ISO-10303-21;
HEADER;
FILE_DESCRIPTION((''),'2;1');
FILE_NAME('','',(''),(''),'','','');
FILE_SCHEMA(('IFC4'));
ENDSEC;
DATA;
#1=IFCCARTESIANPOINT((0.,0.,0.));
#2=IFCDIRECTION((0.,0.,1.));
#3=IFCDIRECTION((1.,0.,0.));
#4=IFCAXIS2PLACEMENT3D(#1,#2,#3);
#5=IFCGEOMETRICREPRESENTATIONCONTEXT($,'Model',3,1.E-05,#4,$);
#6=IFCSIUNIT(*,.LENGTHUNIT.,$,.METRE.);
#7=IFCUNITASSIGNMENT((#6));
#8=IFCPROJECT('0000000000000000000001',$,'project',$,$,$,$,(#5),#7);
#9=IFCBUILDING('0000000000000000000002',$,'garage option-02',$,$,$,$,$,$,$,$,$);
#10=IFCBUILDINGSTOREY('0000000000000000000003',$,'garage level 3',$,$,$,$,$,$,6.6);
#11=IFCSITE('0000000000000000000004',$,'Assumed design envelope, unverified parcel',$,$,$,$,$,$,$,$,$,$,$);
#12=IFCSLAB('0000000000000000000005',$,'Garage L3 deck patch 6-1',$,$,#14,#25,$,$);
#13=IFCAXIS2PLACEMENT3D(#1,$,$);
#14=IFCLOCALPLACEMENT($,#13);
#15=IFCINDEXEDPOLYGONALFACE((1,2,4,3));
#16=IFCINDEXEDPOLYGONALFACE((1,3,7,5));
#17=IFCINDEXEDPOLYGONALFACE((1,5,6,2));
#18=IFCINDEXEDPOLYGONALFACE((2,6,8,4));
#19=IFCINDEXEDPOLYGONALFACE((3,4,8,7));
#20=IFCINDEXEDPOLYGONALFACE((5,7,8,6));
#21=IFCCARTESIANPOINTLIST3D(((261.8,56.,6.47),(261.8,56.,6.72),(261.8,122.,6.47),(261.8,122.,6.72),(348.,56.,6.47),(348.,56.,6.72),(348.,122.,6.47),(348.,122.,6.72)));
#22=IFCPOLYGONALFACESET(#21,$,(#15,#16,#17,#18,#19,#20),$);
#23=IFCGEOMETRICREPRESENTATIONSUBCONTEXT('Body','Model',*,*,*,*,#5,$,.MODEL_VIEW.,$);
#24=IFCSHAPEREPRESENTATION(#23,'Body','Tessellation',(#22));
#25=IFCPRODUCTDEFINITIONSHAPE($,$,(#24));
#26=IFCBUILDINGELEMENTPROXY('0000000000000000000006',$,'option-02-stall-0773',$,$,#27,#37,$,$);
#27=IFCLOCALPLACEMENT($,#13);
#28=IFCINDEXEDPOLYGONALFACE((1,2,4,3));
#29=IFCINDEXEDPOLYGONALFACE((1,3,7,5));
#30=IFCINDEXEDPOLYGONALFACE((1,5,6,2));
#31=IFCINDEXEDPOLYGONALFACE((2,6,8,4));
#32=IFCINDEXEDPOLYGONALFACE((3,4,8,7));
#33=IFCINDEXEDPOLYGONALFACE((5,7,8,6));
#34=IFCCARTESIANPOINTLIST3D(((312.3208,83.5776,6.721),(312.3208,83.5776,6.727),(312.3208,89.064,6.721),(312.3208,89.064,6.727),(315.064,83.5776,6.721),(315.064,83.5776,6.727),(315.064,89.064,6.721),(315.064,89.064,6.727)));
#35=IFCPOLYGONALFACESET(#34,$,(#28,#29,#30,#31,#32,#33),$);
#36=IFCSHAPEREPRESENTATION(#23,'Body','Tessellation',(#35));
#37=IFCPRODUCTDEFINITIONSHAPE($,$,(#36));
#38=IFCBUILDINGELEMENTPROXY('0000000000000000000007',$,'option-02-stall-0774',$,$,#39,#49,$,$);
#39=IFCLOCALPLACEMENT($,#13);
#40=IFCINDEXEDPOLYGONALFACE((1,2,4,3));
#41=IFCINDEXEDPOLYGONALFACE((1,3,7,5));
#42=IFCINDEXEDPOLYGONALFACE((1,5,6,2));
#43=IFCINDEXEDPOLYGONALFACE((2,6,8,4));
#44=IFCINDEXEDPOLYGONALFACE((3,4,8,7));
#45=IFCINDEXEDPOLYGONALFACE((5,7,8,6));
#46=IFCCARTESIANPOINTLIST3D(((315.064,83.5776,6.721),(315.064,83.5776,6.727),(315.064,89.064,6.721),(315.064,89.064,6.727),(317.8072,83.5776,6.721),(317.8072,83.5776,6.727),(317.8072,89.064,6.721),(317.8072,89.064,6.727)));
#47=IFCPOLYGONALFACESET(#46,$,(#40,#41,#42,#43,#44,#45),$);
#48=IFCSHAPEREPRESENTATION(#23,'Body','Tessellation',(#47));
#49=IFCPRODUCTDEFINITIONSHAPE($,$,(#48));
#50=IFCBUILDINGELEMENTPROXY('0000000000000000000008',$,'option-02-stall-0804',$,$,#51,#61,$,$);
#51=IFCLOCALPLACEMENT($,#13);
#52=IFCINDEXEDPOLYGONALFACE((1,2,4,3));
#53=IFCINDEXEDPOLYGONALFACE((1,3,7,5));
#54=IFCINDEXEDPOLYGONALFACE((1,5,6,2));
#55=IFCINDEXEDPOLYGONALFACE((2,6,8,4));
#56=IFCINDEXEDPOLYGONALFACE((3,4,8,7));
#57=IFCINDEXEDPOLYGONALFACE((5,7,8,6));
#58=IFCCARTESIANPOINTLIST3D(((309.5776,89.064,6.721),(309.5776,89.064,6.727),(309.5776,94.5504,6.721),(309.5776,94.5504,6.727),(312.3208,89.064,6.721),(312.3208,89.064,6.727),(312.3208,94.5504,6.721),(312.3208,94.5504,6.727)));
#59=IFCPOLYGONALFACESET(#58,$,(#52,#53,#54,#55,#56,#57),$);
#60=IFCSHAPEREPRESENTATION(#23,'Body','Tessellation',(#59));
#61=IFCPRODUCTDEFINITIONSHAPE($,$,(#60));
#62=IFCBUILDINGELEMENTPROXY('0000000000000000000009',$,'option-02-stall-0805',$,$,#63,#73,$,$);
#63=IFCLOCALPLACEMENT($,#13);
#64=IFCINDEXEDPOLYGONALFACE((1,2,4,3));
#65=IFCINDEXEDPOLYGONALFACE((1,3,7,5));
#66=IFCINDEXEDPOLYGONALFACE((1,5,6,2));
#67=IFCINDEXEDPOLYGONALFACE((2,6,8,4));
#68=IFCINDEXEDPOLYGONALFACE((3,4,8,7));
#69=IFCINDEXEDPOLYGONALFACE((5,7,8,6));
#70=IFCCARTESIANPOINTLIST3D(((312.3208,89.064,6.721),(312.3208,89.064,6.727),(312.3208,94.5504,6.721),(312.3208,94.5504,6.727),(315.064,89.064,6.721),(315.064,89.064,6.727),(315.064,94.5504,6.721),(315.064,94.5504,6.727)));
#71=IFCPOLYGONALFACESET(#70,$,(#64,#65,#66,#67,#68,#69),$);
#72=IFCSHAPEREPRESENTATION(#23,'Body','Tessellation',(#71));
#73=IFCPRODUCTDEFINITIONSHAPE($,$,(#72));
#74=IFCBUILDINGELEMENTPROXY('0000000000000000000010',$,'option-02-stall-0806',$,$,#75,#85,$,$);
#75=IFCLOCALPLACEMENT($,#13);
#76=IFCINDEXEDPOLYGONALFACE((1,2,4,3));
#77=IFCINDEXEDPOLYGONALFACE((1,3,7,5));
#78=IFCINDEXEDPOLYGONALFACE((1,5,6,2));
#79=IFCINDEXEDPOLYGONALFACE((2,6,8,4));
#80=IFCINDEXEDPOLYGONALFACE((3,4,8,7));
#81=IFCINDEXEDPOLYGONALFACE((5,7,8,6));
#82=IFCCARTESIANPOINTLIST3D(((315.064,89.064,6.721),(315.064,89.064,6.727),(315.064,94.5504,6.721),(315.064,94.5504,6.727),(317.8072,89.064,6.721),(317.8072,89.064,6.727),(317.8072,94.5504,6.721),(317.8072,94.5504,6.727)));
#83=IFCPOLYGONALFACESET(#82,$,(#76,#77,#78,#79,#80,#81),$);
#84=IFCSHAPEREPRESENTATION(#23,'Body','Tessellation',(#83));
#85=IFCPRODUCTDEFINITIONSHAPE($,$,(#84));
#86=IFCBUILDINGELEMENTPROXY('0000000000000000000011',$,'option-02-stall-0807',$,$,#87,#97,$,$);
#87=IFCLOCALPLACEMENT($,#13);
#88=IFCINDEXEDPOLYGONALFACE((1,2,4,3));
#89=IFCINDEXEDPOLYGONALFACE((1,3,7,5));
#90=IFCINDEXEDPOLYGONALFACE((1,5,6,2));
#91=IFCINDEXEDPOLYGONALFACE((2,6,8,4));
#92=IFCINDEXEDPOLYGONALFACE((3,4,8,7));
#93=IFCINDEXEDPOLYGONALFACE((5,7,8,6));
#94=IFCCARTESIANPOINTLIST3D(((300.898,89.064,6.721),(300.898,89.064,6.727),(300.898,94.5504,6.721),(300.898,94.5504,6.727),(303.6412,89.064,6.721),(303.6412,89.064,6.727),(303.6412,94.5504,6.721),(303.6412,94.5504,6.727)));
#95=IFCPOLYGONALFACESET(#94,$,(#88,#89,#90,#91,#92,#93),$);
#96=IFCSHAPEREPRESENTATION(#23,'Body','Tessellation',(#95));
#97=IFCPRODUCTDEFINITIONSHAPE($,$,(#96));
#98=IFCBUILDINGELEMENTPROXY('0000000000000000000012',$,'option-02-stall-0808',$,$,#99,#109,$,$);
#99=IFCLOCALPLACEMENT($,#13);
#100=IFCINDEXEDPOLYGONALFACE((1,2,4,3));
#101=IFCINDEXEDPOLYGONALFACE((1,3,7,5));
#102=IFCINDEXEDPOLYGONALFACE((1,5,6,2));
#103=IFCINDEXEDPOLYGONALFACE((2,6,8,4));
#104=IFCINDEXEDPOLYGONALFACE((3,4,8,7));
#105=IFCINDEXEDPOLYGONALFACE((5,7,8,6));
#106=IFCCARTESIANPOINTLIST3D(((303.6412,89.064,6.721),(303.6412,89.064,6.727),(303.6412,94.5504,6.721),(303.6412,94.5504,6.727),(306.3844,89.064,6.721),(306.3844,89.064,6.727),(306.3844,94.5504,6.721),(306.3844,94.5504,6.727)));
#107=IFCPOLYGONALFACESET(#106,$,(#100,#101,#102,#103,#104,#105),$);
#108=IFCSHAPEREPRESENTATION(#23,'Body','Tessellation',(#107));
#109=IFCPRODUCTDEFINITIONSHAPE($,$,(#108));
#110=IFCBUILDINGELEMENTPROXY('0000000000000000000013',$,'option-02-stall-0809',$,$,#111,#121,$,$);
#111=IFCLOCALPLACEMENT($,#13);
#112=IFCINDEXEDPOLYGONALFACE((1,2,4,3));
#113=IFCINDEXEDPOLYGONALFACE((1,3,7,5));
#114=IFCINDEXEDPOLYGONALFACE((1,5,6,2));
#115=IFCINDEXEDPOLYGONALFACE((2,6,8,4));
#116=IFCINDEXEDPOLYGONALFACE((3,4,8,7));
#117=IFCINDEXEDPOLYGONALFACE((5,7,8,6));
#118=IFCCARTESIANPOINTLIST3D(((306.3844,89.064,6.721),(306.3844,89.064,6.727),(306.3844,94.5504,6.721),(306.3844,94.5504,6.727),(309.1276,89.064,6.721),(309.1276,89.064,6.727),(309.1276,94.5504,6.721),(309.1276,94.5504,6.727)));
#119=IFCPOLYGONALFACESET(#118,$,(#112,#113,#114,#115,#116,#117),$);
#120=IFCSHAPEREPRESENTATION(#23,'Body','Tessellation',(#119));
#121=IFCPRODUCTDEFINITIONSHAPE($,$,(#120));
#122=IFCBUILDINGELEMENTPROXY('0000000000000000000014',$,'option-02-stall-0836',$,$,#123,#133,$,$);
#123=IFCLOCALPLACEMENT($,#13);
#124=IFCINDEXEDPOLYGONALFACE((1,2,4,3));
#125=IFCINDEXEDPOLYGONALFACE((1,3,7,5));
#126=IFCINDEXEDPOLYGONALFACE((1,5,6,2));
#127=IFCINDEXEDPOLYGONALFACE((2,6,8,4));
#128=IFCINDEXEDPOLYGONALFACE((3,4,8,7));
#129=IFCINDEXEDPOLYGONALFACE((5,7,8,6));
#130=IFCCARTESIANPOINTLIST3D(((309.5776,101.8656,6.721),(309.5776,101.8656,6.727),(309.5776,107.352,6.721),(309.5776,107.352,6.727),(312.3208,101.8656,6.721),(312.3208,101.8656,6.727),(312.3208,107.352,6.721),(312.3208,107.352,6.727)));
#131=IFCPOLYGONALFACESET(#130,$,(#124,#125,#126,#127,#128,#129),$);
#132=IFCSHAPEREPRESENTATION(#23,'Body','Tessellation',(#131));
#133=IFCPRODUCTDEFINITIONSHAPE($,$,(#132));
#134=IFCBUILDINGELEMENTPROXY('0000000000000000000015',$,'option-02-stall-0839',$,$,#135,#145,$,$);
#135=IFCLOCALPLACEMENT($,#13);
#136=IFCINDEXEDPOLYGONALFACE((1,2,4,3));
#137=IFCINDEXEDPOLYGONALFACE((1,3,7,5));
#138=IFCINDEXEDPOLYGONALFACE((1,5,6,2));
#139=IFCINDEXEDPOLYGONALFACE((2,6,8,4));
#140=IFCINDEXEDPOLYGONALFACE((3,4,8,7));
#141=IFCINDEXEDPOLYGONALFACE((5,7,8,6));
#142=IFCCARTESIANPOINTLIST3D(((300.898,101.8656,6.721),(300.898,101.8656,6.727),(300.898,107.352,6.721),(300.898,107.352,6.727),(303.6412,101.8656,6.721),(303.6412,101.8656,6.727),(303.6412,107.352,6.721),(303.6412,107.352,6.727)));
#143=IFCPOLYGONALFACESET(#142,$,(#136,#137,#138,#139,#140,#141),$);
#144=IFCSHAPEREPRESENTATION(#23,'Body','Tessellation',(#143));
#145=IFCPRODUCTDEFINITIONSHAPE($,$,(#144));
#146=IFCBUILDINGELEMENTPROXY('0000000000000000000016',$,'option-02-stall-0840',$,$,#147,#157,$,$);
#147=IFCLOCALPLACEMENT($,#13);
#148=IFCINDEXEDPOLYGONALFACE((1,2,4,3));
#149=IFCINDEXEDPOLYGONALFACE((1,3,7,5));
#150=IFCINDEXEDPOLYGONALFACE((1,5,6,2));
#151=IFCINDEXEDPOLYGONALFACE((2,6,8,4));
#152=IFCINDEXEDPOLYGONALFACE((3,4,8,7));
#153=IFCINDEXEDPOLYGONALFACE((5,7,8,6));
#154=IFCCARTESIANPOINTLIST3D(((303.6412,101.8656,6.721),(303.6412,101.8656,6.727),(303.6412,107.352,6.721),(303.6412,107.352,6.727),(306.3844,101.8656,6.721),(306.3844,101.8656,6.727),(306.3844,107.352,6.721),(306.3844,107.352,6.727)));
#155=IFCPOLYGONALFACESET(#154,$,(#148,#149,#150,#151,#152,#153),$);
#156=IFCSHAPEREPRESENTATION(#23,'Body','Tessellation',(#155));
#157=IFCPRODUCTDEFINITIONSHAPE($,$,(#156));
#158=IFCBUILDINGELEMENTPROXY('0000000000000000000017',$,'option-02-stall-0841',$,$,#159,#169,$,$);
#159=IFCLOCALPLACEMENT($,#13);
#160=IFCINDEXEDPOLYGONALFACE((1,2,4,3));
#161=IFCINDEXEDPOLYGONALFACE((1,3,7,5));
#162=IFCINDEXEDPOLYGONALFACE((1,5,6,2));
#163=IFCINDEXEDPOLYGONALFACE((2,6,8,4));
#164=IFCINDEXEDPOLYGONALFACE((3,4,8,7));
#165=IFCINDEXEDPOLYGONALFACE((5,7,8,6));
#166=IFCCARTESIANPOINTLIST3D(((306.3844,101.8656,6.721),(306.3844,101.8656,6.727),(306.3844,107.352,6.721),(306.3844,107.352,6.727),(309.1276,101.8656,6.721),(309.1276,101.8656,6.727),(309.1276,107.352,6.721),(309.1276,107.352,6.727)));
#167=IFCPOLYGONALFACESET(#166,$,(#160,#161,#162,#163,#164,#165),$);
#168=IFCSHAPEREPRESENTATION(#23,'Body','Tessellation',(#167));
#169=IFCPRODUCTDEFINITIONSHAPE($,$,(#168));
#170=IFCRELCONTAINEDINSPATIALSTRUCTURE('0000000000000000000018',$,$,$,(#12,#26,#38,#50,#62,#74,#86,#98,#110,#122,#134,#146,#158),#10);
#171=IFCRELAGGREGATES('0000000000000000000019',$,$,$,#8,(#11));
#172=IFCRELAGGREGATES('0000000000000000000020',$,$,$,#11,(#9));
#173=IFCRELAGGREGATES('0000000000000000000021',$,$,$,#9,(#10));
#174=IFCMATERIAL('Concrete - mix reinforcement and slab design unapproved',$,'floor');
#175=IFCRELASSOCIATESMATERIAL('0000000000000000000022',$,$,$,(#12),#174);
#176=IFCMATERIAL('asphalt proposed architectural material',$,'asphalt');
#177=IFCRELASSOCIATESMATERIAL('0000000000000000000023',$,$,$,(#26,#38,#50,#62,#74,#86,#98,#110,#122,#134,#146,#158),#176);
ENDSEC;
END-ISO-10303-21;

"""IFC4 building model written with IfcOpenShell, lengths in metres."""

from ifc_helpers import new_model, si_unit, frame, origin_with_axes, place, context, subcontext, project, spatial, rectangle, extrude, material, element, save


model = new_model("IFC4")

# Units and contexts
model_context = context("Model", 3, precision=1e-05, world=origin_with_axes())
body_context = subcontext(model_context, "Body", "Model", "MODEL_VIEW")
ifc_project = project(units=[si_unit("LENGTHUNIT", "METRE")], contexts=[model_context])

# Site, building, storey
site = spatial("IfcSite", under=ifc_project, Name="Assumed design envelope, unverified parcel")
building = spatial("IfcBuilding", under=site, Name="garage option-02")
storey = spatial("IfcBuildingStorey", under=building, Name="garage level 3", Elevation=6.6)

# Shared definitions
ifc_material_1 = material(Name="Concrete - mix reinforcement and slab design unapproved", Category="floor")

# Slab
slab_placement = place(None, frame((304.9, 89.0, 6.47), z_axis=(0.0, 0.0, 1.0), x_axis=(1.0, 0.0, 0.0)))
element("IfcSlab", 1, at=slab_placement, inside=storey, material=ifc_material_1, Name="Garage L3 deck patch 6-1", context=body_context, shape_type="SweptSolid", body=[
    extrude(rectangle(XDim=86.2, YDim=66.0), origin_with_axes(), (0.0, 0.0, 1.0), 0.25),
])

# Building element proxies
ifc_material_2 = material(Name="asphalt proposed architectural material", Category="asphalt")
for number, where, z_axis, x_axis, name in (
    (2, (313.6924, 86.3208, 6.721), (0.0, 0.0, 1.0), (1.0, 0.0, 0.0), "option-02-stall-0773"),
    (3, (316.4356, 86.3208, 6.721), (0.0, 0.0, 1.0), (1.0, 0.0, 0.0), "option-02-stall-0774"),
    (4, (310.9492, 91.8072, 6.721), (0.0, 0.0, 1.0), (1.0, 0.0, 0.0), "option-02-stall-0804"),
    (5, (313.6924, 91.8072, 6.721), (0.0, 0.0, 1.0), (1.0, 0.0, 0.0), "option-02-stall-0805"),
    (6, (316.4356, 91.8072, 6.721), (0.0, 0.0, 1.0), (1.0, 0.0, 0.0), "option-02-stall-0806"),
    (7, (302.2696, 91.8072, 6.721), (0.0, 0.0, 1.0), (1.0, 0.0, 0.0), "option-02-stall-0807"),
    (8, (305.0128, 91.8072, 6.721), (0.0, 0.0, 1.0), (1.0, 0.0, 0.0), "option-02-stall-0808"),
    (9, (307.756, 91.8072, 6.721), (0.0, 0.0, 1.0), (1.0, 0.0, 0.0), "option-02-stall-0809"),
    (10, (310.9492, 104.6088, 6.721), (0.0, 0.0, 1.0), (1.0, 0.0, 0.0), "option-02-stall-0836"),
    (11, (302.2696, 104.6088, 6.721), (0.0, 0.0, 1.0), (1.0, 0.0, 0.0), "option-02-stall-0839"),
    (12, (305.0128, 104.6088, 6.721), (0.0, 0.0, 1.0), (1.0, 0.0, 0.0), "option-02-stall-0840"),
    (13, (307.756, 104.6088, 6.721), (0.0, 0.0, 1.0), (1.0, 0.0, 0.0), "option-02-stall-0841"),
):
    element("IfcBuildingElementProxy", number, at=place(None, frame(where, z_axis=z_axis, x_axis=x_axis)), inside=storey, material=ifc_material_2, Name=name, context=body_context, shape_type="SweptSolid", body=[
        extrude(rectangle(XDim=2.7432, YDim=5.4864), origin_with_axes(), (0.0, 0.0, 1.0), 0.006),
    ])

save(model, "model.ifc")
